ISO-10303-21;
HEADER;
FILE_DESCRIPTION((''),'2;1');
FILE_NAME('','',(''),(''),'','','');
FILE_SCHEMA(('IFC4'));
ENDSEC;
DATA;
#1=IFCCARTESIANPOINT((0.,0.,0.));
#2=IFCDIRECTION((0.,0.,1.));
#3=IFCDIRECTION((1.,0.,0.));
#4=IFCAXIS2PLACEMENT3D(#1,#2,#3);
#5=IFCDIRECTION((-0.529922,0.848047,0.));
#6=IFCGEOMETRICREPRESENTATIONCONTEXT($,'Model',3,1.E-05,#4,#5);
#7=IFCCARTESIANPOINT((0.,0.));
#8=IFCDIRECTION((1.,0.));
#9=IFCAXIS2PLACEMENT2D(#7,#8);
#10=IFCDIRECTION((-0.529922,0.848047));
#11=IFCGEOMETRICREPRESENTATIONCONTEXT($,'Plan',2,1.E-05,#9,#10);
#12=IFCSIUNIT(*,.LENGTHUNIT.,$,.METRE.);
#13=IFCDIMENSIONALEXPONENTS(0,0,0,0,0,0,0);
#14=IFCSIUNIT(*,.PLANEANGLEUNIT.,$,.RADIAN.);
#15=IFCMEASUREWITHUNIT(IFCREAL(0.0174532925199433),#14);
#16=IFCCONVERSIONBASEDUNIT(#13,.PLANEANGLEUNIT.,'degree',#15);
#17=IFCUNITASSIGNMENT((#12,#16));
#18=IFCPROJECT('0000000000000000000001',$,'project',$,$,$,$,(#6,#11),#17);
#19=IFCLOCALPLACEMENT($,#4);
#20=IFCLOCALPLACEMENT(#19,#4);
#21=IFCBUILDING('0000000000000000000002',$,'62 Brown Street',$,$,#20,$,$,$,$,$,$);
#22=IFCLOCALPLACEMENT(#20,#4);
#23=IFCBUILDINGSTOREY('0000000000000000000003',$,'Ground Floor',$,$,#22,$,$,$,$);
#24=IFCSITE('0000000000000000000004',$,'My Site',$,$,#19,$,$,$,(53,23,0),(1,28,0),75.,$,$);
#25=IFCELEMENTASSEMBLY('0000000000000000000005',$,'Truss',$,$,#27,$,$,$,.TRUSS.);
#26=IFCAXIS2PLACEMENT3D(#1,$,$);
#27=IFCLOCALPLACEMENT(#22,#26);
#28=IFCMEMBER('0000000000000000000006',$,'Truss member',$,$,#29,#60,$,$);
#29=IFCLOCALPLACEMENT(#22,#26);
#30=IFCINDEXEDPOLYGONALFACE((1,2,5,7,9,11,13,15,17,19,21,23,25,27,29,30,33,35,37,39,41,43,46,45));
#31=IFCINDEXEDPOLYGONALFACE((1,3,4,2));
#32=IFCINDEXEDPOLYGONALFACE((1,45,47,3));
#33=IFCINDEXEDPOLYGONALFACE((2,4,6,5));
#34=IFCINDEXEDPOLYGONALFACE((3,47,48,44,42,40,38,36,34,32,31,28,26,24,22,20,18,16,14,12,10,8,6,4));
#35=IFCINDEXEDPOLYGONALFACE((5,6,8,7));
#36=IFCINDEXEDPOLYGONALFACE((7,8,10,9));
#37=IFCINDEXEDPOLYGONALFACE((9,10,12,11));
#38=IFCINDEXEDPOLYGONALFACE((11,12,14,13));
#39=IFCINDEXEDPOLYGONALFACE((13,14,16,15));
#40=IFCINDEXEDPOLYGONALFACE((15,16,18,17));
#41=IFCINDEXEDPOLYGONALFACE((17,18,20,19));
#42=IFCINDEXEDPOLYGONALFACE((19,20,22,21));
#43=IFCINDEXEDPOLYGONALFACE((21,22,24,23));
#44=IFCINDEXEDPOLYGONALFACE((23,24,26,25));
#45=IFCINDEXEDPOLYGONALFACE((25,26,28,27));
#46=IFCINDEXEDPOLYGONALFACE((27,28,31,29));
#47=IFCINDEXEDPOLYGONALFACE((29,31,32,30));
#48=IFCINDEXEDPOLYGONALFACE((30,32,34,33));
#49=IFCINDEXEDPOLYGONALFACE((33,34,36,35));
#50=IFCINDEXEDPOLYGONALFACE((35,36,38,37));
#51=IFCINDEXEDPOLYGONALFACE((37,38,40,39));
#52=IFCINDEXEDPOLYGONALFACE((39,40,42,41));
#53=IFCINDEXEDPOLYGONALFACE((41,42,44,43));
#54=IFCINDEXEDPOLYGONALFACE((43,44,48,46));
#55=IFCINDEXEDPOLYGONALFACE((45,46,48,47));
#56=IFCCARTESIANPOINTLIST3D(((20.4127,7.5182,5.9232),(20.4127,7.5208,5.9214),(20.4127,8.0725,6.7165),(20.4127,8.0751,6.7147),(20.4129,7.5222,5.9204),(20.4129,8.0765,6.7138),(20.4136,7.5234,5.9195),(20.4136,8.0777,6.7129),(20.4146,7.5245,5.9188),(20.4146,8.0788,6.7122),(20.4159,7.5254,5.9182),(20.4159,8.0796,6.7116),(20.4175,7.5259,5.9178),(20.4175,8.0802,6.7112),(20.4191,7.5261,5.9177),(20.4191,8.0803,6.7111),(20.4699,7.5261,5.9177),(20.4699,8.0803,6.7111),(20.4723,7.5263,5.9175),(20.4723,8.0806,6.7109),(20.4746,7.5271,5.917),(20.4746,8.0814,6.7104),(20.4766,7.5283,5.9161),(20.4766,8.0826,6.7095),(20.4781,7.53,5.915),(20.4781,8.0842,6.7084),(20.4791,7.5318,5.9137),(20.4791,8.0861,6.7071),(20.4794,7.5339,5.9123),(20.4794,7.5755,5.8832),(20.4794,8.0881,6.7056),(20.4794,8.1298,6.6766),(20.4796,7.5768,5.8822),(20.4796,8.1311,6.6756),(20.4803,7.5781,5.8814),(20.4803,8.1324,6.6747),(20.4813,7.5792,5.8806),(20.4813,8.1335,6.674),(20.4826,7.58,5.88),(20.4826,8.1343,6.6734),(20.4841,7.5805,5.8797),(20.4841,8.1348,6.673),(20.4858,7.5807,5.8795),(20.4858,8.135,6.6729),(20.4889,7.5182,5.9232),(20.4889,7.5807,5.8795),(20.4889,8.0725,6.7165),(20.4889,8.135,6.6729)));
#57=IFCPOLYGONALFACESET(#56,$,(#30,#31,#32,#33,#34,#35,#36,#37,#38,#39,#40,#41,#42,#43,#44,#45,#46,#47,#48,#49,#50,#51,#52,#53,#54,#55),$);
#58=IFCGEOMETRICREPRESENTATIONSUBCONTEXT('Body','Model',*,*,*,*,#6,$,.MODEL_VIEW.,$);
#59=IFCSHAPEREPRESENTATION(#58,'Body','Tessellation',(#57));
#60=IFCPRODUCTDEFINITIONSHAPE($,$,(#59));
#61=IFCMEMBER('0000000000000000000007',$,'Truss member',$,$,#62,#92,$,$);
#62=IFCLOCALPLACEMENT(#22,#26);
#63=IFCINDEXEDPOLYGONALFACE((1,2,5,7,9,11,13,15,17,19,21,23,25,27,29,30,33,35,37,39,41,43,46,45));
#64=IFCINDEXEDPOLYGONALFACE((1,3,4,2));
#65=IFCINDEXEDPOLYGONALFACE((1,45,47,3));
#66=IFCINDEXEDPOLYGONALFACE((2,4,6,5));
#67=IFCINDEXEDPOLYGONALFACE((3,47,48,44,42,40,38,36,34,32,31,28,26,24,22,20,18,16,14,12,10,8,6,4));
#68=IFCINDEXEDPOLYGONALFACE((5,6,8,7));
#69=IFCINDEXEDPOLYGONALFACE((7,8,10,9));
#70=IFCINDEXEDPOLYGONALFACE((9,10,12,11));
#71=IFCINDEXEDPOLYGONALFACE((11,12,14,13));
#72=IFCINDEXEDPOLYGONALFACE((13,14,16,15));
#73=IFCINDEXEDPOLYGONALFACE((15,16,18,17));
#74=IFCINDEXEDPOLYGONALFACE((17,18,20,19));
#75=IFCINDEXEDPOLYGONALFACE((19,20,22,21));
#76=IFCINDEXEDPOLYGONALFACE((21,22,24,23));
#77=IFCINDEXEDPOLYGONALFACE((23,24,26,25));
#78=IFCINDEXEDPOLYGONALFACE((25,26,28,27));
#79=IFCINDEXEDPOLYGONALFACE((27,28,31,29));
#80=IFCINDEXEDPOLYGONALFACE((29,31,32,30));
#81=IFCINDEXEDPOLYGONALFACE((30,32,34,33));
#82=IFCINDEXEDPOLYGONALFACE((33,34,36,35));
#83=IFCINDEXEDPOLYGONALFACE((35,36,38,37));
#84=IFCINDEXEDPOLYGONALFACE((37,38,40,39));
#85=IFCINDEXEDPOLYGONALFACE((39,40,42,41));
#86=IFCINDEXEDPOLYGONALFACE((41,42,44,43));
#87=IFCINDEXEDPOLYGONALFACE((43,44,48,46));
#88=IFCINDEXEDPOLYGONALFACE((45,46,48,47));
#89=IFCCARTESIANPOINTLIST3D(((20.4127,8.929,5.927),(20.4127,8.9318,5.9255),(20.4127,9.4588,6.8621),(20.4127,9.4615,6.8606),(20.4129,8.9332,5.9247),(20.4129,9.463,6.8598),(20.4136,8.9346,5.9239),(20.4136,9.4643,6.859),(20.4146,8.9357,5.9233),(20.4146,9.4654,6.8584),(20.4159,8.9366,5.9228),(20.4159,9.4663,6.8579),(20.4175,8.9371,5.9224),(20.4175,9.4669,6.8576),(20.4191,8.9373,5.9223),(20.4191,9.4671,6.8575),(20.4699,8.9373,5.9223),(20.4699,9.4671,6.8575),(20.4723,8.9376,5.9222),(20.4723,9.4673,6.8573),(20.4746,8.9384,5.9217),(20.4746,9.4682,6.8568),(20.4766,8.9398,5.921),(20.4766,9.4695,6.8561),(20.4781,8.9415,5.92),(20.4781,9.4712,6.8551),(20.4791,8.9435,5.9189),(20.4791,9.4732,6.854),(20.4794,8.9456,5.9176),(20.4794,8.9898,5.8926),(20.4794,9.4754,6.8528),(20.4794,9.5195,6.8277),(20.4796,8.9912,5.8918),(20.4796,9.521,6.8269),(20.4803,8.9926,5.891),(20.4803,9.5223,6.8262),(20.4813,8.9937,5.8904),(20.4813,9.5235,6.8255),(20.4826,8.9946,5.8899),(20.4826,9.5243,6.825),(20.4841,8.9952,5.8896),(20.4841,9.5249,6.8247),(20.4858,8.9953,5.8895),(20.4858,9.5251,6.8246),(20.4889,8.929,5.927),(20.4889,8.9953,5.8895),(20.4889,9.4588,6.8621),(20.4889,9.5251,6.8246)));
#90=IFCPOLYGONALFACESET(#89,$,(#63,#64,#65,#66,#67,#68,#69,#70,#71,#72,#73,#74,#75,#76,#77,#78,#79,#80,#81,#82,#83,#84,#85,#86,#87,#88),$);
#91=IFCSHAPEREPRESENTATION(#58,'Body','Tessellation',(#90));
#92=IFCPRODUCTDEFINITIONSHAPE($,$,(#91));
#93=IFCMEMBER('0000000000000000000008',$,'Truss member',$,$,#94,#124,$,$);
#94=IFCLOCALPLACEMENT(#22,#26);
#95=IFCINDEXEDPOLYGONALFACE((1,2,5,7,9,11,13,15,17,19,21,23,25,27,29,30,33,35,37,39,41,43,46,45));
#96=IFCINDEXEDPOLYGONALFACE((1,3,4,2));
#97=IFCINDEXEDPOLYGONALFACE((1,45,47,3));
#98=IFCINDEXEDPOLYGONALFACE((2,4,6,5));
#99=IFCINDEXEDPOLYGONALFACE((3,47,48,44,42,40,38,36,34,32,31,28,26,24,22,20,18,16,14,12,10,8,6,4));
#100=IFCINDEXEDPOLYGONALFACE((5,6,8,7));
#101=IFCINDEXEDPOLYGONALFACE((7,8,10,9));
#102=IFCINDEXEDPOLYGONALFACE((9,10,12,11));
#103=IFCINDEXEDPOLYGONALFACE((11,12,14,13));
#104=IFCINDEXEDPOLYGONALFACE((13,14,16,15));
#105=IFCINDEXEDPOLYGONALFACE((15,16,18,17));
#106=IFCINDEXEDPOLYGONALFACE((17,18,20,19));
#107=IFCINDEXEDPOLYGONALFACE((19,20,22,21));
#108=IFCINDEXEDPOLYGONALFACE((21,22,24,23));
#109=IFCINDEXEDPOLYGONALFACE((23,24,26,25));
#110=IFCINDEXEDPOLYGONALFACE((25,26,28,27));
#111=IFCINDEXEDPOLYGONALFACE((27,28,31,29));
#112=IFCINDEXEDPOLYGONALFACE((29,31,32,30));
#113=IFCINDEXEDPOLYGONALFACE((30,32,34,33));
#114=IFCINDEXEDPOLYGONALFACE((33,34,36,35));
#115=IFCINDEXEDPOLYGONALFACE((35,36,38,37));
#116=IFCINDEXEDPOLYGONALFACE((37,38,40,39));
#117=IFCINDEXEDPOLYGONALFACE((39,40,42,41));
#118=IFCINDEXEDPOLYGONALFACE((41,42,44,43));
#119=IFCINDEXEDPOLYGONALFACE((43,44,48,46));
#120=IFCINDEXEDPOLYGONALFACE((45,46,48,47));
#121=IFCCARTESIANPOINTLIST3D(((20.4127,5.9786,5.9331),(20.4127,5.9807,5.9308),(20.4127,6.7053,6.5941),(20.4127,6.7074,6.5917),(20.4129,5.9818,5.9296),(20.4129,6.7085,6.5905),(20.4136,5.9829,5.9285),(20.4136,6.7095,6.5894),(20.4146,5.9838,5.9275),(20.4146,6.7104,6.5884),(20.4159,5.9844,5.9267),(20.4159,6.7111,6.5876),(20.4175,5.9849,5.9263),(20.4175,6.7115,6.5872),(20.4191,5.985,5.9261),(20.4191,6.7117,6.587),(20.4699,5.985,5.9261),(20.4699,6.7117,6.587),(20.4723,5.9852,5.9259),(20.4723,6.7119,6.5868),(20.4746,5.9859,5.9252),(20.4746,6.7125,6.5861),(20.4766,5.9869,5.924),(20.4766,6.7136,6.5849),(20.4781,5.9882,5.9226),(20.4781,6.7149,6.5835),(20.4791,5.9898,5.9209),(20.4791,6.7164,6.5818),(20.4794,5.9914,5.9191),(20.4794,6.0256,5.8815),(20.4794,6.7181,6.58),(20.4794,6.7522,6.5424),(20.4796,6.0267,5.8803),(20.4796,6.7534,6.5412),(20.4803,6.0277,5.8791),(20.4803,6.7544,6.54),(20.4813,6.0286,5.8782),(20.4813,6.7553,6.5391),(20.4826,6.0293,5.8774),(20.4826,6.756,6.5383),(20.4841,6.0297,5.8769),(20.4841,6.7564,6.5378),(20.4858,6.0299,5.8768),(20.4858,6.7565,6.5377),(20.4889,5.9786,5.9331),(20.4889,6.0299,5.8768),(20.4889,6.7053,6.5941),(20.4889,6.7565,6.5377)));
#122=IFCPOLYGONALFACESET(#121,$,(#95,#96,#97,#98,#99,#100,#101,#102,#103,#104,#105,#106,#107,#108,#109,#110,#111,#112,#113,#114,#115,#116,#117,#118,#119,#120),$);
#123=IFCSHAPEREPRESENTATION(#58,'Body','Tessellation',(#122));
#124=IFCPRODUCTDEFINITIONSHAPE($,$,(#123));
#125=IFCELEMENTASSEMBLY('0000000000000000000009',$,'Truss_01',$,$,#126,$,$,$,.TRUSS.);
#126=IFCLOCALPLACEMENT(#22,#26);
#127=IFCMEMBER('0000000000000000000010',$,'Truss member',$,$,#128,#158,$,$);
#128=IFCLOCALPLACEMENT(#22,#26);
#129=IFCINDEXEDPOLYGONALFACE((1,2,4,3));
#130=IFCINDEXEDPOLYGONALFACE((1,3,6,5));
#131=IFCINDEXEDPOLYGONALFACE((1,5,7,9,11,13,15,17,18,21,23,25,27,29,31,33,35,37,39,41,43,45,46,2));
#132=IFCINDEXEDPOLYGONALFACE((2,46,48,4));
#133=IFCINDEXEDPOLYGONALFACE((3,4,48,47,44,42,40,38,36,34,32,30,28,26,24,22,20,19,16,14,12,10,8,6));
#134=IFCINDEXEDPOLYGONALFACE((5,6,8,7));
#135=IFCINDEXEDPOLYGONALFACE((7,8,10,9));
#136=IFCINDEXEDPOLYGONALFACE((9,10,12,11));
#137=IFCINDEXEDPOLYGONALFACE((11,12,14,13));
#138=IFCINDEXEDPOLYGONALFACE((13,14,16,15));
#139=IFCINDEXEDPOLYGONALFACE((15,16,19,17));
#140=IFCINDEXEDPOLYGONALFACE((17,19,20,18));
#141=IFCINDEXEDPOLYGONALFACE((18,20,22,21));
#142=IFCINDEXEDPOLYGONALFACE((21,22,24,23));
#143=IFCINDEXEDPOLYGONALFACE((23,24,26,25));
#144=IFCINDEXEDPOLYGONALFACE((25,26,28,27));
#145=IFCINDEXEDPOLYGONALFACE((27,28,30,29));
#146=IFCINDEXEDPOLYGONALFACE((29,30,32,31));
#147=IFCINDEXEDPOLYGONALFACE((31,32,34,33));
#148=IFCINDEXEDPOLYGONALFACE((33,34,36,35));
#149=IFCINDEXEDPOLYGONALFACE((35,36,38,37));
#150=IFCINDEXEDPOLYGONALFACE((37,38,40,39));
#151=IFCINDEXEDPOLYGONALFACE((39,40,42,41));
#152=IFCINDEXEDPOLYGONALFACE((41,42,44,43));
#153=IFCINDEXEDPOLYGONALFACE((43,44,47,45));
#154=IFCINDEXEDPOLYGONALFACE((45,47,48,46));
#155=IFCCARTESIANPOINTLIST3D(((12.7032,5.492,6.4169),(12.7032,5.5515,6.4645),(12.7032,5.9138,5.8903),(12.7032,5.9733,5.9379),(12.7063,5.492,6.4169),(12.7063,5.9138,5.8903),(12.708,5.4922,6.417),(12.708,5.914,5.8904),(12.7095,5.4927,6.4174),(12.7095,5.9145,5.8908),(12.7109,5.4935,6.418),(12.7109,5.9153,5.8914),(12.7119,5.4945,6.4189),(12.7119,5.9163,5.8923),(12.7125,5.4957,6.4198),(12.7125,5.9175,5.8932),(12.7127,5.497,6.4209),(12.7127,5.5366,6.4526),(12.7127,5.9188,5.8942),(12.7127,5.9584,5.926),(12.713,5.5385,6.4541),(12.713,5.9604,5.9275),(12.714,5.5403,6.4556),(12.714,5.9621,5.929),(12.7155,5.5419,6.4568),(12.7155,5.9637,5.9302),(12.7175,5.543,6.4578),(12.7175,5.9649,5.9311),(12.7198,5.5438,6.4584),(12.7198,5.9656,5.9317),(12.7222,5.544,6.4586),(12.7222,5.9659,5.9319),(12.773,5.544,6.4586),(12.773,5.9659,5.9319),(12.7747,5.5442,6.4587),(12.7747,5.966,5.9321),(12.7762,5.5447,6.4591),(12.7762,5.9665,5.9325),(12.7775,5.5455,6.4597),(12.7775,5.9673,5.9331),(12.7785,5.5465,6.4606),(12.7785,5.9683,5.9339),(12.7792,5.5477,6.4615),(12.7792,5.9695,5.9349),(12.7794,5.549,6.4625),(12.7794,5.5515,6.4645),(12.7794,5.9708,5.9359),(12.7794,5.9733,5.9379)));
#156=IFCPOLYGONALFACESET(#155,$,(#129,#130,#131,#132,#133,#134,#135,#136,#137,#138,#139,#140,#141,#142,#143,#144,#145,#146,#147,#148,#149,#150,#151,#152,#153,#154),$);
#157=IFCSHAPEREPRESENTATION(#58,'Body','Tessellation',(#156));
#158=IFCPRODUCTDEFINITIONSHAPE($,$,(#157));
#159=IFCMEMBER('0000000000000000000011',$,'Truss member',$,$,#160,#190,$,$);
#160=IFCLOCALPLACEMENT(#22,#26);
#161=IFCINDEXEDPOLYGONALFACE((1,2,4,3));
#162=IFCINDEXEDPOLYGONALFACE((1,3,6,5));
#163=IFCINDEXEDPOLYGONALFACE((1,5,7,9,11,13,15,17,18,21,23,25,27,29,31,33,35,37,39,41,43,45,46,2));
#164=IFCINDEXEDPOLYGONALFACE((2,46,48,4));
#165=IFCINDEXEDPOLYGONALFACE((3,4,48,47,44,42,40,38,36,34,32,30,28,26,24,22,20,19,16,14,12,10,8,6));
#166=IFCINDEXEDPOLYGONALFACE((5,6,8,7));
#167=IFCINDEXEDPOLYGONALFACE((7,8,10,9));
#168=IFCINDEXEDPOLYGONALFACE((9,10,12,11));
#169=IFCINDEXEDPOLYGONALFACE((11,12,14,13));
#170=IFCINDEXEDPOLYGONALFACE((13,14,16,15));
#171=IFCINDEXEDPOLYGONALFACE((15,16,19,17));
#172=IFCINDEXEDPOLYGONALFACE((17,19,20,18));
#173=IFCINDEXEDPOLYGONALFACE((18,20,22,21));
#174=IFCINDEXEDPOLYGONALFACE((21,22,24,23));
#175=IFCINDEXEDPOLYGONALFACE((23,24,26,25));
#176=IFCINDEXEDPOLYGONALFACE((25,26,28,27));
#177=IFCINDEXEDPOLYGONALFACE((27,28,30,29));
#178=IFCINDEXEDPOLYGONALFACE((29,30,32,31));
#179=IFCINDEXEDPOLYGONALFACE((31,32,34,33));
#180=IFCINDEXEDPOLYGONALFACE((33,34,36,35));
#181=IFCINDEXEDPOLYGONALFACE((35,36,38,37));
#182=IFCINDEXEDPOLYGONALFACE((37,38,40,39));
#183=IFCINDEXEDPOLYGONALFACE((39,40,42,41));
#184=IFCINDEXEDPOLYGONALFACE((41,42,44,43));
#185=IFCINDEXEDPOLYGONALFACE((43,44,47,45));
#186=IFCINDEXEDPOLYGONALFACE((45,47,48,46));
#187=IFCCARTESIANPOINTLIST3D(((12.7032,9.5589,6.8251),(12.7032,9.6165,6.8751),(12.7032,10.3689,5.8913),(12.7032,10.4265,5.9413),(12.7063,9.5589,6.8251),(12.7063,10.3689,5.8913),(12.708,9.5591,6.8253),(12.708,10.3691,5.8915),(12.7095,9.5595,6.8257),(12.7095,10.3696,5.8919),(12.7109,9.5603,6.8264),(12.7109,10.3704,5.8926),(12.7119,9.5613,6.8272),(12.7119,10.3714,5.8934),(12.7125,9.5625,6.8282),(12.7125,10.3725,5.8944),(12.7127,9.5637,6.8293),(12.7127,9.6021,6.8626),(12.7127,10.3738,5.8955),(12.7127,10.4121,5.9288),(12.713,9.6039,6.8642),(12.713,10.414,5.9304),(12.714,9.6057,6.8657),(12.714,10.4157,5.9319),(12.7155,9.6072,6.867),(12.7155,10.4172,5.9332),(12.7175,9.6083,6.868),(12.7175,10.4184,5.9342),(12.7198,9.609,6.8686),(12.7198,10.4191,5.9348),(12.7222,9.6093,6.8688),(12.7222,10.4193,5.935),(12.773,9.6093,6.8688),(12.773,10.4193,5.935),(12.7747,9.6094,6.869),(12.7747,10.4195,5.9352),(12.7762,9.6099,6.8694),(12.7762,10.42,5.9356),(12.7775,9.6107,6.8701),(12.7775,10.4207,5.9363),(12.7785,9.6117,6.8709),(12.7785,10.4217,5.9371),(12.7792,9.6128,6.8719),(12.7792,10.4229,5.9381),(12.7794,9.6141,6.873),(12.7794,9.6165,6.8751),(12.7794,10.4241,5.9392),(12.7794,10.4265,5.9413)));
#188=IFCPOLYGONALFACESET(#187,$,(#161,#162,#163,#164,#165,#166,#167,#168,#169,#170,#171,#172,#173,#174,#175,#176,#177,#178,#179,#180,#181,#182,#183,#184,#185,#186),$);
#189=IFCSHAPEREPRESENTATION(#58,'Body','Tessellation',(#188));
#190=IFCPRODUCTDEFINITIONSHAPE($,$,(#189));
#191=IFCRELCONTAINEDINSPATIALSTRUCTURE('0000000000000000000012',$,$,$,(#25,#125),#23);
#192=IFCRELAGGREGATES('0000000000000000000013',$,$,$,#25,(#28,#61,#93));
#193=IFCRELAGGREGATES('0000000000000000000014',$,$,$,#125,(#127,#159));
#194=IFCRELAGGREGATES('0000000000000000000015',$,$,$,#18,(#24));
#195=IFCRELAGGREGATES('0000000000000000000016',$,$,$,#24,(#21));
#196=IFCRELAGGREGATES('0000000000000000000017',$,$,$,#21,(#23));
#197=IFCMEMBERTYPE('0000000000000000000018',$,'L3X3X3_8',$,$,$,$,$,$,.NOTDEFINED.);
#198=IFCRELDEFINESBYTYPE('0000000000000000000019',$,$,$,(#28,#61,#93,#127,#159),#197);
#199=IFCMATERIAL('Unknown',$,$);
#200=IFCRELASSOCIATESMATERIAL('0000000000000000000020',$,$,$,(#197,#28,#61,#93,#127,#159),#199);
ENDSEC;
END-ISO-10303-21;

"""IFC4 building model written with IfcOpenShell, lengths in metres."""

from ifc_helpers import new_model, entity, si_unit, converted_unit, direction, frame, origin_with_axes, origin_2d_with_axis, place, context, subcontext, project, spatial, l_section, extrude, material, material_profile, profile_set, profile_usage, type_object, element, aggregate, save


model = new_model("IFC4")

# Units and contexts
model_context = context("Model", 3, precision=1e-05, world=origin_with_axes(), true_north=direction((-0.529922, 0.848047, 0.0)))
plan_context = context("Plan", 2, precision=1e-05, world=origin_2d_with_axis(), true_north=direction((-0.529922, 0.848047)))
body_context_1 = subcontext(model_context, "Body", "Model", "MODEL_VIEW")
ifc_project = project(units=[si_unit("LENGTHUNIT", "METRE"), converted_unit("PLANEANGLEUNIT", "degree", entity("IfcReal", 0.0174532925199433), si_unit("PLANEANGLEUNIT", "RADIAN"), dimensions=[0, 0, 0, 0, 0, 0, 0])], contexts=[model_context, plan_context])

# Site, building, storey
site_placement = place(None, origin_with_axes())
site = spatial("IfcSite", under=ifc_project, at=site_placement, Name="My Site", RefLatitude=(53, 23, 0), RefLongitude=(1, 28, 0), RefElevation=75.0)
building_placement = place(site_placement, origin_with_axes())
building = spatial("IfcBuilding", under=site, at=building_placement, Name="62 Brown Street")
storey_placement = place(building_placement, origin_with_axes())
storey = spatial("IfcBuildingStorey", under=building, at=storey_placement, Name="Ground Floor")

# Element assemblies, members
assembly_1_placement = place(storey_placement, frame((20.5032, 10.4288, 6.9738), z_axis=(0.0, 0.0, 1.0), x_axis=(1.0, 0.0, 0.0)))
assembly_1 = element("IfcElementAssembly", 1, at=assembly_1_placement, inside=storey, Name="Truss", PredefinedType="TRUSS")
ifc_material_1 = material(Name="Unknown")
ifc_material_profile_1 = material_profile(ifc_material_1, l_section(Depth=0.0762, Width=0.0762, Thickness=0.0095, FilletRadius=0.0095, EdgeRadius=0.0064))
ifc_profile_set_1 = profile_set([ifc_material_profile_1])
ifc_profile_usage_1 = profile_usage(ifc_profile_set_1, cardinal=5)
member_type_1 = type_object("IfcMemberType", Name="L3X3X3_8", PredefinedType="NOTDEFINED", material=ifc_profile_set_1)
member_1_placement = place(assembly_1_placement, frame((-0.0524, -2.325, -0.279), z_axis=(0.000001, -0.572709, -0.819759), x_axis=(-1.0, -0.000001, 0.0)))
member_1 = element("IfcMember", 2, at=member_1_placement, type_object=member_type_1, material=ifc_profile_usage_1, Name="Truss member", context=body_context_1, shape_type="SweptSolid", body=[
    extrude(l_section(Depth=0.0762, Width=0.0762, Thickness=0.0095, FilletRadius=0.0095, EdgeRadius=0.0064), origin_with_axes(), (0.0, 0.0, 1.0), 0.9678),
])
ifc_profile_usage_2 = profile_usage(ifc_profile_set_1, cardinal=5)
member_2_placement = place(assembly_1_placement, frame((-0.0524, -0.9369, -0.1304), z_axis=(0.0, -0.492899, -0.870086), x_axis=(-1.0, 0.0, 0.0)))
member_2 = element("IfcMember", 3, at=member_2_placement, type_object=member_type_1, material=ifc_profile_usage_2, Name="Truss member", context=body_context_1, shape_type="SweptSolid", body=[
    extrude(l_section(Depth=0.0762, Width=0.0762, Thickness=0.0095, FilletRadius=0.0095, EdgeRadius=0.0064), origin_with_axes(), (0.0, 0.0, 1.0), 1.0747),
])
ifc_profile_usage_3 = profile_usage(ifc_profile_set_1, cardinal=5)
member_3_placement = place(assembly_1_placement, frame((-0.0524, -3.6979, -0.4079), z_axis=(0.000001, -0.739785, -0.672843), x_axis=(-1.0, -0.000001, 0.0)))
member_3 = element("IfcMember", 4, at=member_3_placement, type_object=member_type_1, material=ifc_profile_usage_3, Name="Truss member", context=body_context_1, shape_type="SweptSolid", body=[
    extrude(l_section(Depth=0.0762, Width=0.0762, Thickness=0.0095, FilletRadius=0.0095, EdgeRadius=0.0064), origin_with_axes(), (0.0, 0.0, 1.0), 0.9823),
])
aggregate(assembly_1, [member_1, member_2, member_3])
assembly_2_placement = place(storey_placement, frame((12.7032, 10.4288, 6.9738), z_axis=(0.0, 0.0, 1.0), x_axis=(1.0, 0.0, 0.0)))
assembly_2 = element("IfcElementAssembly", 5, at=assembly_2_placement, inside=storey, Name="Truss_01", PredefinedType="TRUSS")
ifc_profile_usage_4 = profile_usage(ifc_profile_set_1, cardinal=5)
member_4_placement = place(assembly_2_placement, frame((0.0381, -4.907, -0.5331), z_axis=(-0.000001, 0.625169, -0.780489), x_axis=(1.0, 0.000001, 0.0)))
member_4 = element("IfcMember", 6, at=member_4_placement, type_object=member_type_1, material=ifc_profile_usage_4, Name="Truss member", context=body_context_1, shape_type="SweptSolid", body=[
    extrude(l_section(Depth=0.0762, Width=0.0762, Thickness=0.0095, FilletRadius=0.0095, EdgeRadius=0.0064), origin_with_axes(), (0.0, 0.0, 1.0), 0.6747),
])
ifc_profile_usage_5 = profile_usage(ifc_profile_set_1, cardinal=5)
member_5_placement = place(assembly_2_placement, frame((0.0381, -0.8411, -0.1236), z_axis=(-0.000001, 0.655276, -0.755389), x_axis=(1.0, 0.000001, 0.0)))
member_5 = element("IfcMember", 7, at=member_5_placement, type_object=member_type_1, material=ifc_profile_usage_5, Name="Truss member", context=body_context_1, shape_type="SweptSolid", body=[
    extrude(l_section(Depth=0.0762, Width=0.0762, Thickness=0.0095, FilletRadius=0.0095, EdgeRadius=0.0064), origin_with_axes(), (0.0, 0.0, 1.0), 1.2362),
])

aggregate(assembly_2, [member_4, member_5])

save(model, "model.ifc")
